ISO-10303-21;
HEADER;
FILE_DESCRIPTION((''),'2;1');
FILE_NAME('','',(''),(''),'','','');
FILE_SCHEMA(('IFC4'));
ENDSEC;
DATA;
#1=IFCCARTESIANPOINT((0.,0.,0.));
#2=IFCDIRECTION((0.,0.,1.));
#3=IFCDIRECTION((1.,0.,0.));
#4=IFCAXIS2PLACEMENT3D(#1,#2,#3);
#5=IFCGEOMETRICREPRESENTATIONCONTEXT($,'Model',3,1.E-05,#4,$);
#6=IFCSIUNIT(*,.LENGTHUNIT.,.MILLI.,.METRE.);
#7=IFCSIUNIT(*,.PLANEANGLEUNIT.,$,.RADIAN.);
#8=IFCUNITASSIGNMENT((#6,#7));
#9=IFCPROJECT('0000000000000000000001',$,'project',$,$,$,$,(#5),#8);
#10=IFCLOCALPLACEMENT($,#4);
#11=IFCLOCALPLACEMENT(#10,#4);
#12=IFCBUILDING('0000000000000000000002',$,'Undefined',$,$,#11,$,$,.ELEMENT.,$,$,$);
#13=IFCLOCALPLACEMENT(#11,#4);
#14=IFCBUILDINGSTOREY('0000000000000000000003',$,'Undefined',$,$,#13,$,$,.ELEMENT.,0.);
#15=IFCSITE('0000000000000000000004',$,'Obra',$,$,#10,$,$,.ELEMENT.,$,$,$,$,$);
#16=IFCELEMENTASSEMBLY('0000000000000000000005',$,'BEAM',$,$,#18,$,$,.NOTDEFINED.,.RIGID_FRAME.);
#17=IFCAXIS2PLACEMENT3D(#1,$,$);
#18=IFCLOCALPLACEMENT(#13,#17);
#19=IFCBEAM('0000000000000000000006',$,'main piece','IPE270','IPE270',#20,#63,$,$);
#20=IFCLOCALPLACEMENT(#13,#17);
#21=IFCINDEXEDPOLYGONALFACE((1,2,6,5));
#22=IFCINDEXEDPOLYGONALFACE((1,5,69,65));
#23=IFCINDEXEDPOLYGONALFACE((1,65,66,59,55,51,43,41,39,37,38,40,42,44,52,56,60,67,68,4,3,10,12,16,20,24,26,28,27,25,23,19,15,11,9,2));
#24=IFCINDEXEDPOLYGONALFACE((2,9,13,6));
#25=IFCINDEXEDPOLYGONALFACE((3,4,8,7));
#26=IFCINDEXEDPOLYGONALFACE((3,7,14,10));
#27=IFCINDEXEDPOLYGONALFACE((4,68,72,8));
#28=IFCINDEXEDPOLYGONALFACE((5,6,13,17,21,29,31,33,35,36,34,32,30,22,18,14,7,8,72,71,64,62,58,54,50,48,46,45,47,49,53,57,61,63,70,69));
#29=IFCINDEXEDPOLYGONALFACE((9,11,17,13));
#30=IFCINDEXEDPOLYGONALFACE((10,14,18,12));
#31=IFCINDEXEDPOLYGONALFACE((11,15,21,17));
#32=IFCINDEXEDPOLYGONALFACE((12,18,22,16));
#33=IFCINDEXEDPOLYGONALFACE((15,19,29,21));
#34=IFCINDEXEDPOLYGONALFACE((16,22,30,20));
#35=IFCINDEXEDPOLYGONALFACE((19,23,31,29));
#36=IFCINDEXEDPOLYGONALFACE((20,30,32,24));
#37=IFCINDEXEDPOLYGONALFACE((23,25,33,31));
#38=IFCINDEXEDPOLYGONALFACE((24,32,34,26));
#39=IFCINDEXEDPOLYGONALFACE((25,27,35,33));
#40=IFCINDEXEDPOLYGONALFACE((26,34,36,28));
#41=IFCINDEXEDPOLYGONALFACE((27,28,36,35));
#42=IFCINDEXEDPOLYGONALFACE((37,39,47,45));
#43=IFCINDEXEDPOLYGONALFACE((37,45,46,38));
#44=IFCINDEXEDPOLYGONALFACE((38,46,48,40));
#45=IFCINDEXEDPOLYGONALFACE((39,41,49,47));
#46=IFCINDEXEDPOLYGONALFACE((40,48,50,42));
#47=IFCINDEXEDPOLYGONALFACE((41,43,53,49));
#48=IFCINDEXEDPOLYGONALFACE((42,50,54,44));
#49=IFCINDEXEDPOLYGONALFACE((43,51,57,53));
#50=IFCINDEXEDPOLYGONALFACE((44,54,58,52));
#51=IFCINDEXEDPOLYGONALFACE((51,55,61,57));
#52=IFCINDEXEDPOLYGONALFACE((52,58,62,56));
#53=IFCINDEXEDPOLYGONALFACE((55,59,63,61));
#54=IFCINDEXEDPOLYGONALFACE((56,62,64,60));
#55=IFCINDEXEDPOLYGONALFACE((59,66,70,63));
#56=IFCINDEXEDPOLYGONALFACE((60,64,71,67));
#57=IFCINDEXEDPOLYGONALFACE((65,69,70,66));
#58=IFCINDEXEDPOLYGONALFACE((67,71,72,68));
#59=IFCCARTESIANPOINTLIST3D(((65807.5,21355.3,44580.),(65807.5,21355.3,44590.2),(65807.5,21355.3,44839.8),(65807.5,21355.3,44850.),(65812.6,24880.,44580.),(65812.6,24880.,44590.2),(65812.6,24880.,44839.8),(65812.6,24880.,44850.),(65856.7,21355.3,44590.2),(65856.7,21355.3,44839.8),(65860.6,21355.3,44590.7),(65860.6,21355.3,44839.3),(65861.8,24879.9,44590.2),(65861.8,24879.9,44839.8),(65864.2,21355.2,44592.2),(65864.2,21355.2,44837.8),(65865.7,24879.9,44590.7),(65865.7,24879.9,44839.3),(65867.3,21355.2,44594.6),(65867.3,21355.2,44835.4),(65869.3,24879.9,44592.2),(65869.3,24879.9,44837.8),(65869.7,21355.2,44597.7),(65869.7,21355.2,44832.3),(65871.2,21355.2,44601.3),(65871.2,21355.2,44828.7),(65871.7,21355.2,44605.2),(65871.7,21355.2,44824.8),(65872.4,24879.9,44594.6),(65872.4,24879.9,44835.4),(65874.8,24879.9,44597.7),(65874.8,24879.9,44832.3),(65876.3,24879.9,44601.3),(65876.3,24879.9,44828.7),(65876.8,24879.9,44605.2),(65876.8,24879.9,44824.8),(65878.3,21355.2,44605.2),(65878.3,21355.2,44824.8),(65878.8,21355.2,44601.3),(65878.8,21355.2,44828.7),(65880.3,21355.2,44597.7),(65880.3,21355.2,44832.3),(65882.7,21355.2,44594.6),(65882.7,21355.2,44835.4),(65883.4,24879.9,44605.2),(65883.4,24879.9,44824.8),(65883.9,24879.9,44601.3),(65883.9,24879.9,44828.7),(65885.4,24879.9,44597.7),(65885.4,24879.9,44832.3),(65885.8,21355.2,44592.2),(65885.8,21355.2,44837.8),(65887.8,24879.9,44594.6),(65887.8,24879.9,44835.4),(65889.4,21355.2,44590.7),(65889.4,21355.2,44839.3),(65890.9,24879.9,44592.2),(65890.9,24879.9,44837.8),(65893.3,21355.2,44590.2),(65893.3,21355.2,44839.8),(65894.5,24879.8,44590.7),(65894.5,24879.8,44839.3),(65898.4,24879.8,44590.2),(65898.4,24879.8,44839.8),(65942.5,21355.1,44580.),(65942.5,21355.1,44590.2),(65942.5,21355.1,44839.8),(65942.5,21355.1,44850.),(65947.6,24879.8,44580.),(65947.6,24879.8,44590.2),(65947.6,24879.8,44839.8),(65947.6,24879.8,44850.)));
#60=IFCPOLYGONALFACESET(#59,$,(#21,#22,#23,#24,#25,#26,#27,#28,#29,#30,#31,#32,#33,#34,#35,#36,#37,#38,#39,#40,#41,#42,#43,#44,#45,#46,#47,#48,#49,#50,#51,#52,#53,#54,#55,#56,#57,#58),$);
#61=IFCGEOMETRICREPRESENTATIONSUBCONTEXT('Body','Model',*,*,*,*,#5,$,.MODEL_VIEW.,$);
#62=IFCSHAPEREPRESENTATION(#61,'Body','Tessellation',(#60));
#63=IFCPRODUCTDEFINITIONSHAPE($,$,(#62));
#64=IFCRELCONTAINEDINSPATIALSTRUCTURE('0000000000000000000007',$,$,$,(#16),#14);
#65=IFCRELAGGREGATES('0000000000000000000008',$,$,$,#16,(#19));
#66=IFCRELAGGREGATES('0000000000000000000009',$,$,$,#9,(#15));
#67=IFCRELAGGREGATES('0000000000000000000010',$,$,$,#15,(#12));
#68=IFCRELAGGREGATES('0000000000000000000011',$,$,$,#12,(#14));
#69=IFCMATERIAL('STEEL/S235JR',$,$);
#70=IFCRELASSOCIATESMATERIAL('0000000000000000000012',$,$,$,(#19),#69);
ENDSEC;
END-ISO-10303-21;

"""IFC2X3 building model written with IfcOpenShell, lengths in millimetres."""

from ifc_helpers import new_model, si_unit, frame, origin_with_axes, origin_2d_with_axis, place, context, subcontext, project, spatial, i_section, extrude, material, element, aggregate, save


model = new_model("IFC2X3")

# Units and contexts
model_context = context("Model", 3, precision=1e-05, world=origin_with_axes())
body_context = subcontext(model_context, "Body", "Model", "MODEL_VIEW")
ifc_project = project(units=[si_unit("LENGTHUNIT", "METRE", prefix="MILLI"), si_unit("PLANEANGLEUNIT", "RADIAN")], contexts=[model_context])

# Site, building, storey
site_placement = place(None, origin_with_axes())
site = spatial("IfcSite", under=ifc_project, at=site_placement, Name="Obra", CompositionType="ELEMENT")
building_placement = place(site_placement, origin_with_axes())
building = spatial("IfcBuilding", under=site, at=building_placement, Name="Undefined", CompositionType="ELEMENT")
storey_placement = place(building_placement, origin_with_axes())
storey = spatial("IfcBuildingStorey", under=building, at=storey_placement, Name="Undefined", CompositionType="ELEMENT", Elevation=0.0)

# Shared definitions
ifc_material_1 = material(Name="STEEL/S235JR")

# Element assembly, beam
assembly_1_placement = place(storey_placement, origin_with_axes())
assembly_1 = element("IfcElementAssembly", 1, at=assembly_1_placement, inside=storey, Name="BEAM", AssemblyPlace="NOTDEFINED", PredefinedType="RIGID_FRAME")
beam_1_placement = place(assembly_1_placement, frame((65880.1, 24879.9, 44715.0), z_axis=(0.0, 0.0, 1.0), x_axis=(-0.001448, -0.999999, 0.0)))
beam_1 = element("IfcBeam", 2, at=beam_1_placement, material=ifc_material_1, Name="main piece", Description="IPE270", ObjectType="IPE270", context=body_context, shape_type="SweptSolid", body=[
    extrude(i_section(OverallWidth=135.0, OverallDepth=270.0, WebThickness=6.6, FlangeThickness=10.2, FilletRadius=15.0, at=origin_2d_with_axis()), frame((3524.6, 0.0, 0.0), z_axis=(-1.0, 0.0, 0.0), x_axis=(0.0, -1.0, 0.0)), (0.0, 0.0, 1.0), 3524.6),
])
aggregate(assembly_1, [beam_1])

save(model, "model.ifc")
